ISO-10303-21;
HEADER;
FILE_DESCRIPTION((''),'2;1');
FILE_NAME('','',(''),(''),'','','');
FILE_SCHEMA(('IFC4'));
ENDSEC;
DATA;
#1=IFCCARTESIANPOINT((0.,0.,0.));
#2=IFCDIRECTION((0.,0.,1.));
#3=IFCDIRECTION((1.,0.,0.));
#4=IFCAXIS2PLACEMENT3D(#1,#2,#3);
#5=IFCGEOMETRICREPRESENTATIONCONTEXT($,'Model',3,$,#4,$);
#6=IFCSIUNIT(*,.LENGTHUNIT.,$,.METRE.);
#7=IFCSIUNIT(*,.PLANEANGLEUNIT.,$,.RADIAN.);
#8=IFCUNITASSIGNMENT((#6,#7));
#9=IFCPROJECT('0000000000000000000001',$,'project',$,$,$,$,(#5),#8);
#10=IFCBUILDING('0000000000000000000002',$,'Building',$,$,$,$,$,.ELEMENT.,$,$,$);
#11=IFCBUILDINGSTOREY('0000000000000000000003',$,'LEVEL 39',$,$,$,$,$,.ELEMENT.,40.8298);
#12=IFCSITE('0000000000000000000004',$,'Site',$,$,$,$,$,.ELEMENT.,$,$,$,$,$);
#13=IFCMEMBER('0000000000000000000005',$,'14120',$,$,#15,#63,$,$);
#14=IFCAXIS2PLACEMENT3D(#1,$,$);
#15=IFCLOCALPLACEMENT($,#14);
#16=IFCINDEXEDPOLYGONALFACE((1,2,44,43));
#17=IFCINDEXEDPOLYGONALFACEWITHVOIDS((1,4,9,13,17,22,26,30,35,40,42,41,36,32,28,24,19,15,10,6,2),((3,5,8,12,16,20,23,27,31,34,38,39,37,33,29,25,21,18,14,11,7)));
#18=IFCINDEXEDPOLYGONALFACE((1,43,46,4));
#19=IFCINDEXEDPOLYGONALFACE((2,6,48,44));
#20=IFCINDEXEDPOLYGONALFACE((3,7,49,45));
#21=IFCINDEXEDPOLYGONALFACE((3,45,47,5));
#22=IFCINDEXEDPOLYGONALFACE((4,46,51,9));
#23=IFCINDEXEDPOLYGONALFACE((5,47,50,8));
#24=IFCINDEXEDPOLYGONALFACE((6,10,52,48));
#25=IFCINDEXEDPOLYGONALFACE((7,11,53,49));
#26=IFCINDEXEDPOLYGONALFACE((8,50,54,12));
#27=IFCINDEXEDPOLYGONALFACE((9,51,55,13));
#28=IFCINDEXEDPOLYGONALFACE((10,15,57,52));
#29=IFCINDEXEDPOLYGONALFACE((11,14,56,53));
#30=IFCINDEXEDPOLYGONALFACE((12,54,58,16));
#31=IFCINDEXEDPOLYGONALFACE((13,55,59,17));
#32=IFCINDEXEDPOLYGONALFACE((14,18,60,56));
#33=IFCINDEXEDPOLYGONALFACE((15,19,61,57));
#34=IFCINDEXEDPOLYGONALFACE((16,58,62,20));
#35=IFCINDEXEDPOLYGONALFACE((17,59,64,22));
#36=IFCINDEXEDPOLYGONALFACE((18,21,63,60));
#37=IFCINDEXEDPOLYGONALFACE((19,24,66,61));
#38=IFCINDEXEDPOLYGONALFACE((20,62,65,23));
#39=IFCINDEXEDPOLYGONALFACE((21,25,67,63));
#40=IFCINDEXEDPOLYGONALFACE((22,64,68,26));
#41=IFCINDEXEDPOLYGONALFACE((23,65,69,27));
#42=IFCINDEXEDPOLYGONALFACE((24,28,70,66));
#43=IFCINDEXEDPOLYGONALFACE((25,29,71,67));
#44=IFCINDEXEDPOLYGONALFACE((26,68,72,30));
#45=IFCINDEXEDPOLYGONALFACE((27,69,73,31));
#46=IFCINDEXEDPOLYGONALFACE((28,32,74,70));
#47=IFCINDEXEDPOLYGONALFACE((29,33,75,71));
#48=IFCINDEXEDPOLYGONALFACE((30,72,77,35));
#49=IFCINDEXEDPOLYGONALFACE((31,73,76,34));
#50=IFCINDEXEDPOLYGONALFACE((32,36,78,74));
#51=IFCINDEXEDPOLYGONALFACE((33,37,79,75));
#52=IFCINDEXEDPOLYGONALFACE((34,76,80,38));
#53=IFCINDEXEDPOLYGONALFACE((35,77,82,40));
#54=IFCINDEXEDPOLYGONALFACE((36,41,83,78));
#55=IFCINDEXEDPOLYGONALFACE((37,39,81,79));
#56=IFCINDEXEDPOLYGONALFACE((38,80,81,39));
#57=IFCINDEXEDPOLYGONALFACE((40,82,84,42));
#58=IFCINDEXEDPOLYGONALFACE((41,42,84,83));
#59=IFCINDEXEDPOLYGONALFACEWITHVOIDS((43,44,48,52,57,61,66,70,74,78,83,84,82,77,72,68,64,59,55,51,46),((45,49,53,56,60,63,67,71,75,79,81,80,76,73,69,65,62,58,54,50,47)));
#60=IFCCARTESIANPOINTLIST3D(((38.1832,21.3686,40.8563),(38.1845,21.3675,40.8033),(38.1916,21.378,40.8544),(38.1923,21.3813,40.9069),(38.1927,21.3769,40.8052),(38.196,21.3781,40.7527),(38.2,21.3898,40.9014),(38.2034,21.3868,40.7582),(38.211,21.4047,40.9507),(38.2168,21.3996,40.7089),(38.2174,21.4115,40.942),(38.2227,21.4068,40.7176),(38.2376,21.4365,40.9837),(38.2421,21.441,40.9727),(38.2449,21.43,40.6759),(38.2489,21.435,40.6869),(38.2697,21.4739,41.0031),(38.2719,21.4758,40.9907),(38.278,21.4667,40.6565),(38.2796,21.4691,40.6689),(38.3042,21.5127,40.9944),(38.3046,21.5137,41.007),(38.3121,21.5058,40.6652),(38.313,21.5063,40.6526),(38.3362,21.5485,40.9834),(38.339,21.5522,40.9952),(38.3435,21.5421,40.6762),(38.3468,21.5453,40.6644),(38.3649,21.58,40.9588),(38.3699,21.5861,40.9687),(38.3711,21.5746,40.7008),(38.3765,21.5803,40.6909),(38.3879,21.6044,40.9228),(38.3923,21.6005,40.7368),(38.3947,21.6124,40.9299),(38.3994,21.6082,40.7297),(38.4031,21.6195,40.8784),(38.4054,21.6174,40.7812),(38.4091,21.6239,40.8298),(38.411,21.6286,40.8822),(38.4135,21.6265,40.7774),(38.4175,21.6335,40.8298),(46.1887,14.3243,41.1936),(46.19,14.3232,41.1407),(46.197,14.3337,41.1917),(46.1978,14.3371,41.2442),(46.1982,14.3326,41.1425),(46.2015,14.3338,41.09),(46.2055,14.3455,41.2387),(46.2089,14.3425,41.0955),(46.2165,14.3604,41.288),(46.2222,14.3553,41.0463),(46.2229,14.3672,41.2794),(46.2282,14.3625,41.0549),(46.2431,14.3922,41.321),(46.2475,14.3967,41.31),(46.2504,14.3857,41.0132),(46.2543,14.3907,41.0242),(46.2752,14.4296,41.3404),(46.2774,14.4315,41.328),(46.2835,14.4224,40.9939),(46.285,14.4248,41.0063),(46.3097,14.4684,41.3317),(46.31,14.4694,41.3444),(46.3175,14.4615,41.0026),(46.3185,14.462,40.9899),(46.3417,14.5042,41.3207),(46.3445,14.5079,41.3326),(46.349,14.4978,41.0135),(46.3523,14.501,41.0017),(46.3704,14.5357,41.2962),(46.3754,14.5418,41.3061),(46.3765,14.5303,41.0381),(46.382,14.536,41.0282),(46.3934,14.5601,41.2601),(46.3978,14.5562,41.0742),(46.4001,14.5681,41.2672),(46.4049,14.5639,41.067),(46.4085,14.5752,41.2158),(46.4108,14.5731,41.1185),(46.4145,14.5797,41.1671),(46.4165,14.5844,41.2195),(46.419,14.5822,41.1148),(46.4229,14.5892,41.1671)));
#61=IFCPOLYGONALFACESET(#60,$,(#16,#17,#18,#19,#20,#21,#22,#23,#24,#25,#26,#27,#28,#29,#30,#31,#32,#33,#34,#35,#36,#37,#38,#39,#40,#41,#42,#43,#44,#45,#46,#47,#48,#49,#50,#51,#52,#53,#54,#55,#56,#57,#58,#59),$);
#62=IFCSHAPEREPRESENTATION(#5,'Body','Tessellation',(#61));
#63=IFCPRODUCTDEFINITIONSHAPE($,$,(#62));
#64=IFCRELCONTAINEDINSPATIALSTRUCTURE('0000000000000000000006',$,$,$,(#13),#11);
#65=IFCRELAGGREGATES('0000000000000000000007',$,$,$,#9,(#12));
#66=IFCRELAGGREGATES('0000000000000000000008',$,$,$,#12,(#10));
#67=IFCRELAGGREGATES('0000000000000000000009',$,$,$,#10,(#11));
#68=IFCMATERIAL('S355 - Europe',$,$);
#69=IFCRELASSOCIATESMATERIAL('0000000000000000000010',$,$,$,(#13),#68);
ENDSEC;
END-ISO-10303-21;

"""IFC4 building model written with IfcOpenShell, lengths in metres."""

from ifc_helpers import new_model, si_unit, frame, origin_with_axes, origin_2d_with_axis, place, context, project, spatial, hollow_circle, extrude, material, material_profile, profile_set, profile_usage, element, save


model = new_model("IFC4")

# Units and contexts
model_context = context("Model", 3, world=origin_with_axes())
ifc_project = project(units=[si_unit("LENGTHUNIT", "METRE"), si_unit("PLANEANGLEUNIT", "RADIAN")], contexts=[model_context])

# Site, building, storey
site = spatial("IfcSite", under=ifc_project, Name="Site", CompositionType="ELEMENT")
building = spatial("IfcBuilding", under=site, Name="Building", CompositionType="ELEMENT")
storey = spatial("IfcBuildingStorey", under=building, Name="LEVEL 39", CompositionType="ELEMENT", Elevation=40.8298)

# Shared definitions
ifc_material = material(Name="S355 - Europe")

# Member
ifc_material_profile_1 = material_profile(ifc_material, hollow_circle(Radius=0.1778, WallThickness=0.0127, at=origin_2d_with_axis()))
ifc_profile_set_1 = profile_set([ifc_material_profile_1])
ifc_profile_usage_1 = profile_usage(ifc_profile_set_1, cardinal=10)
member_1_placement = place(None, frame((38.3, 21.5, 40.8298), z_axis=(0.750362, -0.66027, 0.031619), x_axis=(0.6606, 0.750738, 0.0)))
element("IfcMember", 1, at=member_1_placement, inside=storey, material=ifc_profile_usage_1, Name="14120", context=model_context, shape_type="SweptSolid", body=[
    extrude(hollow_circle(Radius=0.1778, WallThickness=0.0127, at=origin_2d_with_axis()), origin_with_axes(), (0.0, 0.0, 1.0), 10.6688),
])

save(model, "model.ifc")
